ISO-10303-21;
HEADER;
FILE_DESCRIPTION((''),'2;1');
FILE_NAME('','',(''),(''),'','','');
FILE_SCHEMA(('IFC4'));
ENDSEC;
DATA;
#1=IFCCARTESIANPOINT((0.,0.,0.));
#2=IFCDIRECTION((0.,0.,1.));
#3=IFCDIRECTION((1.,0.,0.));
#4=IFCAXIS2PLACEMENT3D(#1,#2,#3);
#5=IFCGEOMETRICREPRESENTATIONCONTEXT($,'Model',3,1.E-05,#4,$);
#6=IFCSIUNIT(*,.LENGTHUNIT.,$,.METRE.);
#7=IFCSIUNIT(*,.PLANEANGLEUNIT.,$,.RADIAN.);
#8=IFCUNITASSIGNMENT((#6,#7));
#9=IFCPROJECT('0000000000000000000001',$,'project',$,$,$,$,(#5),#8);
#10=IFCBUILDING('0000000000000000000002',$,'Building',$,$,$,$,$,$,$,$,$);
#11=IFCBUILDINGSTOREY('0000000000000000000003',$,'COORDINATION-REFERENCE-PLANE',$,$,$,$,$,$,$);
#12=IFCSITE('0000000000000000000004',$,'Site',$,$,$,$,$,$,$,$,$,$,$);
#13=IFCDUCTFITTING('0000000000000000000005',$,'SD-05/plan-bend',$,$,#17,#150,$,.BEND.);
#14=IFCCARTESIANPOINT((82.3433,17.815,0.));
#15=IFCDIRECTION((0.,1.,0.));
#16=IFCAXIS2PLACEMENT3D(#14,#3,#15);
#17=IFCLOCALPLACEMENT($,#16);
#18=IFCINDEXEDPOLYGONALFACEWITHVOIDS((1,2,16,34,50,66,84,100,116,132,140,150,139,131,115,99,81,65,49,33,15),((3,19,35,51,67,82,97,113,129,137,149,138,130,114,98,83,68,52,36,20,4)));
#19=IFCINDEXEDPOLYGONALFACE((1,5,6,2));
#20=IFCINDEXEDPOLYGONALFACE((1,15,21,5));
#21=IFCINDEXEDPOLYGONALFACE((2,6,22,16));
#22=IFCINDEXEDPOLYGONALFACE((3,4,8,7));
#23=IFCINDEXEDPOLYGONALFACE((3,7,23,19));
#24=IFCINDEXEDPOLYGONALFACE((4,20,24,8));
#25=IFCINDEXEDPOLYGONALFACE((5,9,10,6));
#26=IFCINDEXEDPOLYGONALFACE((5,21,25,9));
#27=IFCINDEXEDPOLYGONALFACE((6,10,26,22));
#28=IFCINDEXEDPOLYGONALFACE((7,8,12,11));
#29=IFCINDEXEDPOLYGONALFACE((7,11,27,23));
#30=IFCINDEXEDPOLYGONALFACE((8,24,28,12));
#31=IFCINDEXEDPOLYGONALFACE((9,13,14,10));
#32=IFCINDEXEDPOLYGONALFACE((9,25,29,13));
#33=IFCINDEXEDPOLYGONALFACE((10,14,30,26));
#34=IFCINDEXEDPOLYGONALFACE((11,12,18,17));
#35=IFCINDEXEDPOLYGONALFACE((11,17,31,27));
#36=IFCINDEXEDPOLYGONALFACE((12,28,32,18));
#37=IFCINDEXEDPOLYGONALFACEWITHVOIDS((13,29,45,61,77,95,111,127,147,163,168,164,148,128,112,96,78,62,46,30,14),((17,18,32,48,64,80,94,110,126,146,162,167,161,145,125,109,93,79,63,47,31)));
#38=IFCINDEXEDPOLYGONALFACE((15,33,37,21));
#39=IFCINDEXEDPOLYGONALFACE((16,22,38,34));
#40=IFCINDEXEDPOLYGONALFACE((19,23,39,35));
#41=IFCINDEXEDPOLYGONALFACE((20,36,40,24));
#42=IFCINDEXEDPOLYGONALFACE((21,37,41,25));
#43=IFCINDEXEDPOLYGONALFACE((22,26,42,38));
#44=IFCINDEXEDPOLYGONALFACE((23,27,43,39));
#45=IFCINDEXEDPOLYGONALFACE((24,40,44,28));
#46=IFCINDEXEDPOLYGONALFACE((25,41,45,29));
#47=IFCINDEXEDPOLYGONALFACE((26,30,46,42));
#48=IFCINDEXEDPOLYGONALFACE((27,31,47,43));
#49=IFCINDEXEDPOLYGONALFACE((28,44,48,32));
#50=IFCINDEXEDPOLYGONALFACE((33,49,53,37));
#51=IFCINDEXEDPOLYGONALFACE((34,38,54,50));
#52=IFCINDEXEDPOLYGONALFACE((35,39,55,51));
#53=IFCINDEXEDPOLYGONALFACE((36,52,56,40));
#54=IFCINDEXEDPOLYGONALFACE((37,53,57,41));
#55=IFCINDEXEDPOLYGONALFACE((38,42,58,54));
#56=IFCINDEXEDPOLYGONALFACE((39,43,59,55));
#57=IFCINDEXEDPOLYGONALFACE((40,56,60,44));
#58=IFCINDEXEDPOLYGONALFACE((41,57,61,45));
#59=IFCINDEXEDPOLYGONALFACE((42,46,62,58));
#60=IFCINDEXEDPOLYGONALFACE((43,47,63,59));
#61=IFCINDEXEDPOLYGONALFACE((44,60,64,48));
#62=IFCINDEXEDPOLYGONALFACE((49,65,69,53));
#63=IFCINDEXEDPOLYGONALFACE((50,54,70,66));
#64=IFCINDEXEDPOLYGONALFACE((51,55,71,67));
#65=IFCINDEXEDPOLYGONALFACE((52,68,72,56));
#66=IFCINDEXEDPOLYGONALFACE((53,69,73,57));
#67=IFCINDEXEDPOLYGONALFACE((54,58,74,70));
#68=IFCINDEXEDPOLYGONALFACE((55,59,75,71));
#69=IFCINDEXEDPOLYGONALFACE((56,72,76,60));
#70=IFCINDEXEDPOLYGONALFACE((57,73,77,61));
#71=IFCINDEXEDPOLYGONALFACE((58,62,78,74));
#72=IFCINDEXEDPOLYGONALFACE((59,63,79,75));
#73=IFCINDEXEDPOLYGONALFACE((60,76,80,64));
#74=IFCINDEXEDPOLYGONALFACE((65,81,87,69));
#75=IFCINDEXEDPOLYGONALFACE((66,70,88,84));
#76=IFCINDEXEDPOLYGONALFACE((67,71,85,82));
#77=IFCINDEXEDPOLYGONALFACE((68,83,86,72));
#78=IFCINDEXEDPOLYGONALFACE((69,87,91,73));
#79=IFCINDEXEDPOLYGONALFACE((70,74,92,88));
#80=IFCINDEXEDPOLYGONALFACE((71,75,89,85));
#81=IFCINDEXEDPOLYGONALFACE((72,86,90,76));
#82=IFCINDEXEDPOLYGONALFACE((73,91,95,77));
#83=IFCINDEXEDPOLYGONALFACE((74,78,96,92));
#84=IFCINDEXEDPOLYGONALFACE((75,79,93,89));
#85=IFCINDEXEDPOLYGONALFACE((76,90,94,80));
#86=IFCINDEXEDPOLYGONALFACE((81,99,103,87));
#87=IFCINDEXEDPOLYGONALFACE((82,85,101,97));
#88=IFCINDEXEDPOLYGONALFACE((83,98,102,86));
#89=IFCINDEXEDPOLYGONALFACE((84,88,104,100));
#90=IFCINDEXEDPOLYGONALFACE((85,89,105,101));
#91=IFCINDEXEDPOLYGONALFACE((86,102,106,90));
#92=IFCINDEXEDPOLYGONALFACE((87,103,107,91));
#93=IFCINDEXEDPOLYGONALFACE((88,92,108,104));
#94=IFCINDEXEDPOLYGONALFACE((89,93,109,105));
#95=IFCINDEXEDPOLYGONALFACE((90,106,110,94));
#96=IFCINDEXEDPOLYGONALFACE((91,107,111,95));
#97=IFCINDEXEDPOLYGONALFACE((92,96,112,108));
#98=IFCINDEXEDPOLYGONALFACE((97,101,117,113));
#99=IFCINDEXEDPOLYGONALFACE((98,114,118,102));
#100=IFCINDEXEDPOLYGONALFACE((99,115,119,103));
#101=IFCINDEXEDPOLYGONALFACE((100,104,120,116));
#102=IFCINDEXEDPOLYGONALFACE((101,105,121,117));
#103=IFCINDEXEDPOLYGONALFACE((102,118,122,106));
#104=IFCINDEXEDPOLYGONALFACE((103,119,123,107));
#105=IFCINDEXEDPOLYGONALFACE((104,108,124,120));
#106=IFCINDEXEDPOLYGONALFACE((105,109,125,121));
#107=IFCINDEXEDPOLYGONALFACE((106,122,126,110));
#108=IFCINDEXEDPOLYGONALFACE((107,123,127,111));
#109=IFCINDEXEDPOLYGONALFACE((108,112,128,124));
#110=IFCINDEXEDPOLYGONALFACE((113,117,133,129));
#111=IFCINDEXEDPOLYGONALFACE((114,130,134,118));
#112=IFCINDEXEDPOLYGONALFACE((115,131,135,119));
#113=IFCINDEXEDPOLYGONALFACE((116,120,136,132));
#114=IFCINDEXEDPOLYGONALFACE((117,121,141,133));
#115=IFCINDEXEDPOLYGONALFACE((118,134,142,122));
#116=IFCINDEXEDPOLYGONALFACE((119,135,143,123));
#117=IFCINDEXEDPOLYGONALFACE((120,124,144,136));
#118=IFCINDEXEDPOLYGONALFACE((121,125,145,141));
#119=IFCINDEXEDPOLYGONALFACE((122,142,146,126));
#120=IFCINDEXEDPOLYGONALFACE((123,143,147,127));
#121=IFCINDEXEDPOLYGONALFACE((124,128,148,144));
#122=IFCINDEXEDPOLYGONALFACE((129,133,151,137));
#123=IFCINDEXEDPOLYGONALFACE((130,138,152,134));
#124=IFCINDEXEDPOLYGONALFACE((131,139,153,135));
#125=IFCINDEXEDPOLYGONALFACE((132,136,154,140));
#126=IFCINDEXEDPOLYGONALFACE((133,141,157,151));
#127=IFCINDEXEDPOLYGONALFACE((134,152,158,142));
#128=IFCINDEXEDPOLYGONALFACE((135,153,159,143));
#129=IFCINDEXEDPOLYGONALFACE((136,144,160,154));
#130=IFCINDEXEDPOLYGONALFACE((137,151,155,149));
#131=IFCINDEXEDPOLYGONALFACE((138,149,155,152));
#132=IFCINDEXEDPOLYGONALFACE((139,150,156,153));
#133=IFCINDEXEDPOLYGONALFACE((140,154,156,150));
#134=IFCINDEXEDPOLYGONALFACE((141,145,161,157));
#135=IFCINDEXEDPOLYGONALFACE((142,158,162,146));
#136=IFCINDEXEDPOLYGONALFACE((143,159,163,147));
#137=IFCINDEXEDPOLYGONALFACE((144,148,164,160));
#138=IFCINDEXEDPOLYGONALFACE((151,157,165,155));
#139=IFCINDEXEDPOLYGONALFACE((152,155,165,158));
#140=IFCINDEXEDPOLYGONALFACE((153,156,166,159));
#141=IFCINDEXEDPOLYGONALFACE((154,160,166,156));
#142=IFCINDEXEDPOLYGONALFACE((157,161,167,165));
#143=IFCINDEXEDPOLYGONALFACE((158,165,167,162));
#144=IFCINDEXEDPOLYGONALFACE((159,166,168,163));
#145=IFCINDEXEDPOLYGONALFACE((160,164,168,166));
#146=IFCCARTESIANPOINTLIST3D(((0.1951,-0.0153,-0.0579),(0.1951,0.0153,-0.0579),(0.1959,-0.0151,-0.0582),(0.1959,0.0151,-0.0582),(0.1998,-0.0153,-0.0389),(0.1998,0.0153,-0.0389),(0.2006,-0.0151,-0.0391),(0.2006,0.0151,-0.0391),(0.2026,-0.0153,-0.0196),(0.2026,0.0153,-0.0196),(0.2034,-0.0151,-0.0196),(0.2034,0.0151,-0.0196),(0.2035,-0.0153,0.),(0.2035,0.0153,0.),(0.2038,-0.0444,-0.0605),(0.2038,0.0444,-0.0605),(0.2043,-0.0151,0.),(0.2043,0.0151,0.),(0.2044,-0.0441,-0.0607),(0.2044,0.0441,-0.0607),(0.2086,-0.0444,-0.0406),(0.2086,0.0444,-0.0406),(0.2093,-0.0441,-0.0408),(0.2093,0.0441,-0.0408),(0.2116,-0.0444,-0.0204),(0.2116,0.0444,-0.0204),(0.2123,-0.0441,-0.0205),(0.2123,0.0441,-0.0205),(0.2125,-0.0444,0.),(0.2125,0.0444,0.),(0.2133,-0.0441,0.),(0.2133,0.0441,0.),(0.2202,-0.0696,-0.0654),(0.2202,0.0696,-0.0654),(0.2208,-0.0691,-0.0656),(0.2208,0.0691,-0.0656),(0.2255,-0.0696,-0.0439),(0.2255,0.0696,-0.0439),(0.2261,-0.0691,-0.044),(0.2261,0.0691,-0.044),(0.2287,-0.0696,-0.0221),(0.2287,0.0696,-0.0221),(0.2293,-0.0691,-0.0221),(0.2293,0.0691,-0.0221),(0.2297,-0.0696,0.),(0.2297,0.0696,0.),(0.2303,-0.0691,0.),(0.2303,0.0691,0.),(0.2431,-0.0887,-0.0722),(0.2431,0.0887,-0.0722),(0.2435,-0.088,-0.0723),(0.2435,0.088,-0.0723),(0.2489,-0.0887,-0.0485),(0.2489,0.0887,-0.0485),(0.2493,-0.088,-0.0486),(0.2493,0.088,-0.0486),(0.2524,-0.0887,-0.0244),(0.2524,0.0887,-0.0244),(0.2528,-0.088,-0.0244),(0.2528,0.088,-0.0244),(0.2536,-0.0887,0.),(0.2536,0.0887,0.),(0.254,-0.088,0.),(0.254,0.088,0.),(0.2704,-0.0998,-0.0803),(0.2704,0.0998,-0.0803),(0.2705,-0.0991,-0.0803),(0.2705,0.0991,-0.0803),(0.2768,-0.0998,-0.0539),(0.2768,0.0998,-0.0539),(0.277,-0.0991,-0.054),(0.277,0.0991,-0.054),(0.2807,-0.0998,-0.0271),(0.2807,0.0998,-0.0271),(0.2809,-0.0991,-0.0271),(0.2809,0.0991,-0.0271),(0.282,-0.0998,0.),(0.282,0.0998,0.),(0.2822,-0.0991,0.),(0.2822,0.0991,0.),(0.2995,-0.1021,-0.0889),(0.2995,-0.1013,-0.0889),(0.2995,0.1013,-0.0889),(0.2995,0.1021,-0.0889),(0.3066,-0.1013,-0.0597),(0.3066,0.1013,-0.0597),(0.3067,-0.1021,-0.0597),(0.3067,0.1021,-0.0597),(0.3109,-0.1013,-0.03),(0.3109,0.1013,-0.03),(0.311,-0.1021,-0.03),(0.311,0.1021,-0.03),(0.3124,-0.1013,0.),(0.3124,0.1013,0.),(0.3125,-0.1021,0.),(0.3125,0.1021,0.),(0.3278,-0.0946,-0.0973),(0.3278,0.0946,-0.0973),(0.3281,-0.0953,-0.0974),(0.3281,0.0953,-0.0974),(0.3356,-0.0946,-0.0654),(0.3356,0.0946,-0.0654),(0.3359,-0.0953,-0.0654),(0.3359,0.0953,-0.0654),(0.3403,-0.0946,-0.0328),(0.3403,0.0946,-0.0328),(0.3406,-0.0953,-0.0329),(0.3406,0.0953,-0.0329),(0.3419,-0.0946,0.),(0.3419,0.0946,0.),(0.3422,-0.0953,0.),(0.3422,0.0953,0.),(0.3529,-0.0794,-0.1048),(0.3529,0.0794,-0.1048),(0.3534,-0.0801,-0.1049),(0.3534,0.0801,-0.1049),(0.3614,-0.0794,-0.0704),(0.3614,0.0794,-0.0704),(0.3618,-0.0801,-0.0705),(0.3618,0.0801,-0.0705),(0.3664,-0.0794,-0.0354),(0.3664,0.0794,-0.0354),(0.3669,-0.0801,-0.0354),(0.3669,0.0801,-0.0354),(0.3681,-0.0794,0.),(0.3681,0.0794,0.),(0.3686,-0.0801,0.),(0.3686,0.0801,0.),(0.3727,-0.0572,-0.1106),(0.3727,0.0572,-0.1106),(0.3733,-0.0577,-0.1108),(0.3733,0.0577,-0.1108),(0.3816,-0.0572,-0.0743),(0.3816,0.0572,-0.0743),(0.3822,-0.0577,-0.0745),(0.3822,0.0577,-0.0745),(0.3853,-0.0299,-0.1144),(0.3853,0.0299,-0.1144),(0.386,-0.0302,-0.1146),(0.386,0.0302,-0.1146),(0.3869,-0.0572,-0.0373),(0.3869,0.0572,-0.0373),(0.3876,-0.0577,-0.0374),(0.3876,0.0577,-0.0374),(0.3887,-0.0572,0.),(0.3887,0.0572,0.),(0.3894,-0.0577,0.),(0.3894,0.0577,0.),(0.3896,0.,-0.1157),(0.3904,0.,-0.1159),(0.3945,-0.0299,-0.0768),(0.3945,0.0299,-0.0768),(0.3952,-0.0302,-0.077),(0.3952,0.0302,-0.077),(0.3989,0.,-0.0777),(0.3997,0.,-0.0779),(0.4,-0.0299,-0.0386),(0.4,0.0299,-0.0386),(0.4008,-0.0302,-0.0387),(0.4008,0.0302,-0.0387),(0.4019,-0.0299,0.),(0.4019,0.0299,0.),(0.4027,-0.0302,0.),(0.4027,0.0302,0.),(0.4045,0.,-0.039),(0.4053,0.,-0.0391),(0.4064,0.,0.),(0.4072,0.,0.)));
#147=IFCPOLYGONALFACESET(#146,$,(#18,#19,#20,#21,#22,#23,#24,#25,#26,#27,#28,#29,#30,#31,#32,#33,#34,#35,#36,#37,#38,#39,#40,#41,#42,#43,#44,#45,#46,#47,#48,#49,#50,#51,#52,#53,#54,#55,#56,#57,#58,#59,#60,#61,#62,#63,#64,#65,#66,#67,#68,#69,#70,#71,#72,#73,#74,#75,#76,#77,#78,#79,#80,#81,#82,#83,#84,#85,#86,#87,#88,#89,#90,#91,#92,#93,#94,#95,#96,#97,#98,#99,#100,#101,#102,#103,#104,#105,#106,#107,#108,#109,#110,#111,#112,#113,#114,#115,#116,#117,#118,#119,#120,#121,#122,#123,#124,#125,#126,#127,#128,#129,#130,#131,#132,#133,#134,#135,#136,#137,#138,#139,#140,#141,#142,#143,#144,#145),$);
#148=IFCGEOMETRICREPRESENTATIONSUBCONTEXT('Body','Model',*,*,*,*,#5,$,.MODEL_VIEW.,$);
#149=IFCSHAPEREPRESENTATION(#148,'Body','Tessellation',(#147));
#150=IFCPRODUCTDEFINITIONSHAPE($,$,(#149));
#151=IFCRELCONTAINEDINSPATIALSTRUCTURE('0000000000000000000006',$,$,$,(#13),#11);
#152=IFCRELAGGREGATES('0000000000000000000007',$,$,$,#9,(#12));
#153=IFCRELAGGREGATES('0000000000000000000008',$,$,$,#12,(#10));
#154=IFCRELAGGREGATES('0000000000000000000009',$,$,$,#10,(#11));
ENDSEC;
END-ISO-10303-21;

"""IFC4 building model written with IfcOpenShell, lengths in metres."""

from ifc_helpers import new_model, entity, si_unit, frame, origin_with_axes, place, context, subcontext, project, spatial, element, save


model = new_model("IFC4")

# Units and contexts
model_context = context("Model", 3, precision=1e-05, world=origin_with_axes())
body_context_1 = subcontext(model_context, "Body", "Model", "MODEL_VIEW")
ifc_project = project(units=[si_unit("LENGTHUNIT", "METRE"), si_unit("PLANEANGLEUNIT", "RADIAN")], contexts=[model_context])

# Site, building, storey
site = spatial("IfcSite", under=ifc_project, Name="Site")
building = spatial("IfcBuilding", under=site, Name="Building")
storey = spatial("IfcBuildingStorey", under=building, Name="COORDINATION-REFERENCE-PLANE")

# Duct fitting
duct_fitting_1_placement = place(None, frame((82.3433, 17.815, 0.0), z_axis=(1.0, 0.0, 0.0), x_axis=(0.0, 1.0, 0.0)))
element("IfcDuctFitting", 1, at=duct_fitting_1_placement, inside=storey, Name="SD-05/plan-bend", PredefinedType="BEND", context=body_context_1, shape_type="SweptSolid", body=[
    entity("IfcRevolvedAreaSolid", entity("IfcCircleHollowProfileDef", "AREA", None, entity("IfcAxis2Placement2D", entity("IfcCartesianPoint", [0.3048, 0.0])), 0.1024, 0.0008), entity("IfcAxis2Placement3D", entity("IfcCartesianPoint", [0.0, 0.0, 0.0]), entity("IfcDirection", [0.0, 0.0, 1.0]), entity("IfcDirection", [1.0, 0.0, 0.0])), entity("IfcAxis1Placement", entity("IfcCartesianPoint", [0.0, 0.0, 0.0]), entity("IfcDirection", [0.0, 1.0, 0.0])), 0.288593),
])

save(model, "model.ifc")
